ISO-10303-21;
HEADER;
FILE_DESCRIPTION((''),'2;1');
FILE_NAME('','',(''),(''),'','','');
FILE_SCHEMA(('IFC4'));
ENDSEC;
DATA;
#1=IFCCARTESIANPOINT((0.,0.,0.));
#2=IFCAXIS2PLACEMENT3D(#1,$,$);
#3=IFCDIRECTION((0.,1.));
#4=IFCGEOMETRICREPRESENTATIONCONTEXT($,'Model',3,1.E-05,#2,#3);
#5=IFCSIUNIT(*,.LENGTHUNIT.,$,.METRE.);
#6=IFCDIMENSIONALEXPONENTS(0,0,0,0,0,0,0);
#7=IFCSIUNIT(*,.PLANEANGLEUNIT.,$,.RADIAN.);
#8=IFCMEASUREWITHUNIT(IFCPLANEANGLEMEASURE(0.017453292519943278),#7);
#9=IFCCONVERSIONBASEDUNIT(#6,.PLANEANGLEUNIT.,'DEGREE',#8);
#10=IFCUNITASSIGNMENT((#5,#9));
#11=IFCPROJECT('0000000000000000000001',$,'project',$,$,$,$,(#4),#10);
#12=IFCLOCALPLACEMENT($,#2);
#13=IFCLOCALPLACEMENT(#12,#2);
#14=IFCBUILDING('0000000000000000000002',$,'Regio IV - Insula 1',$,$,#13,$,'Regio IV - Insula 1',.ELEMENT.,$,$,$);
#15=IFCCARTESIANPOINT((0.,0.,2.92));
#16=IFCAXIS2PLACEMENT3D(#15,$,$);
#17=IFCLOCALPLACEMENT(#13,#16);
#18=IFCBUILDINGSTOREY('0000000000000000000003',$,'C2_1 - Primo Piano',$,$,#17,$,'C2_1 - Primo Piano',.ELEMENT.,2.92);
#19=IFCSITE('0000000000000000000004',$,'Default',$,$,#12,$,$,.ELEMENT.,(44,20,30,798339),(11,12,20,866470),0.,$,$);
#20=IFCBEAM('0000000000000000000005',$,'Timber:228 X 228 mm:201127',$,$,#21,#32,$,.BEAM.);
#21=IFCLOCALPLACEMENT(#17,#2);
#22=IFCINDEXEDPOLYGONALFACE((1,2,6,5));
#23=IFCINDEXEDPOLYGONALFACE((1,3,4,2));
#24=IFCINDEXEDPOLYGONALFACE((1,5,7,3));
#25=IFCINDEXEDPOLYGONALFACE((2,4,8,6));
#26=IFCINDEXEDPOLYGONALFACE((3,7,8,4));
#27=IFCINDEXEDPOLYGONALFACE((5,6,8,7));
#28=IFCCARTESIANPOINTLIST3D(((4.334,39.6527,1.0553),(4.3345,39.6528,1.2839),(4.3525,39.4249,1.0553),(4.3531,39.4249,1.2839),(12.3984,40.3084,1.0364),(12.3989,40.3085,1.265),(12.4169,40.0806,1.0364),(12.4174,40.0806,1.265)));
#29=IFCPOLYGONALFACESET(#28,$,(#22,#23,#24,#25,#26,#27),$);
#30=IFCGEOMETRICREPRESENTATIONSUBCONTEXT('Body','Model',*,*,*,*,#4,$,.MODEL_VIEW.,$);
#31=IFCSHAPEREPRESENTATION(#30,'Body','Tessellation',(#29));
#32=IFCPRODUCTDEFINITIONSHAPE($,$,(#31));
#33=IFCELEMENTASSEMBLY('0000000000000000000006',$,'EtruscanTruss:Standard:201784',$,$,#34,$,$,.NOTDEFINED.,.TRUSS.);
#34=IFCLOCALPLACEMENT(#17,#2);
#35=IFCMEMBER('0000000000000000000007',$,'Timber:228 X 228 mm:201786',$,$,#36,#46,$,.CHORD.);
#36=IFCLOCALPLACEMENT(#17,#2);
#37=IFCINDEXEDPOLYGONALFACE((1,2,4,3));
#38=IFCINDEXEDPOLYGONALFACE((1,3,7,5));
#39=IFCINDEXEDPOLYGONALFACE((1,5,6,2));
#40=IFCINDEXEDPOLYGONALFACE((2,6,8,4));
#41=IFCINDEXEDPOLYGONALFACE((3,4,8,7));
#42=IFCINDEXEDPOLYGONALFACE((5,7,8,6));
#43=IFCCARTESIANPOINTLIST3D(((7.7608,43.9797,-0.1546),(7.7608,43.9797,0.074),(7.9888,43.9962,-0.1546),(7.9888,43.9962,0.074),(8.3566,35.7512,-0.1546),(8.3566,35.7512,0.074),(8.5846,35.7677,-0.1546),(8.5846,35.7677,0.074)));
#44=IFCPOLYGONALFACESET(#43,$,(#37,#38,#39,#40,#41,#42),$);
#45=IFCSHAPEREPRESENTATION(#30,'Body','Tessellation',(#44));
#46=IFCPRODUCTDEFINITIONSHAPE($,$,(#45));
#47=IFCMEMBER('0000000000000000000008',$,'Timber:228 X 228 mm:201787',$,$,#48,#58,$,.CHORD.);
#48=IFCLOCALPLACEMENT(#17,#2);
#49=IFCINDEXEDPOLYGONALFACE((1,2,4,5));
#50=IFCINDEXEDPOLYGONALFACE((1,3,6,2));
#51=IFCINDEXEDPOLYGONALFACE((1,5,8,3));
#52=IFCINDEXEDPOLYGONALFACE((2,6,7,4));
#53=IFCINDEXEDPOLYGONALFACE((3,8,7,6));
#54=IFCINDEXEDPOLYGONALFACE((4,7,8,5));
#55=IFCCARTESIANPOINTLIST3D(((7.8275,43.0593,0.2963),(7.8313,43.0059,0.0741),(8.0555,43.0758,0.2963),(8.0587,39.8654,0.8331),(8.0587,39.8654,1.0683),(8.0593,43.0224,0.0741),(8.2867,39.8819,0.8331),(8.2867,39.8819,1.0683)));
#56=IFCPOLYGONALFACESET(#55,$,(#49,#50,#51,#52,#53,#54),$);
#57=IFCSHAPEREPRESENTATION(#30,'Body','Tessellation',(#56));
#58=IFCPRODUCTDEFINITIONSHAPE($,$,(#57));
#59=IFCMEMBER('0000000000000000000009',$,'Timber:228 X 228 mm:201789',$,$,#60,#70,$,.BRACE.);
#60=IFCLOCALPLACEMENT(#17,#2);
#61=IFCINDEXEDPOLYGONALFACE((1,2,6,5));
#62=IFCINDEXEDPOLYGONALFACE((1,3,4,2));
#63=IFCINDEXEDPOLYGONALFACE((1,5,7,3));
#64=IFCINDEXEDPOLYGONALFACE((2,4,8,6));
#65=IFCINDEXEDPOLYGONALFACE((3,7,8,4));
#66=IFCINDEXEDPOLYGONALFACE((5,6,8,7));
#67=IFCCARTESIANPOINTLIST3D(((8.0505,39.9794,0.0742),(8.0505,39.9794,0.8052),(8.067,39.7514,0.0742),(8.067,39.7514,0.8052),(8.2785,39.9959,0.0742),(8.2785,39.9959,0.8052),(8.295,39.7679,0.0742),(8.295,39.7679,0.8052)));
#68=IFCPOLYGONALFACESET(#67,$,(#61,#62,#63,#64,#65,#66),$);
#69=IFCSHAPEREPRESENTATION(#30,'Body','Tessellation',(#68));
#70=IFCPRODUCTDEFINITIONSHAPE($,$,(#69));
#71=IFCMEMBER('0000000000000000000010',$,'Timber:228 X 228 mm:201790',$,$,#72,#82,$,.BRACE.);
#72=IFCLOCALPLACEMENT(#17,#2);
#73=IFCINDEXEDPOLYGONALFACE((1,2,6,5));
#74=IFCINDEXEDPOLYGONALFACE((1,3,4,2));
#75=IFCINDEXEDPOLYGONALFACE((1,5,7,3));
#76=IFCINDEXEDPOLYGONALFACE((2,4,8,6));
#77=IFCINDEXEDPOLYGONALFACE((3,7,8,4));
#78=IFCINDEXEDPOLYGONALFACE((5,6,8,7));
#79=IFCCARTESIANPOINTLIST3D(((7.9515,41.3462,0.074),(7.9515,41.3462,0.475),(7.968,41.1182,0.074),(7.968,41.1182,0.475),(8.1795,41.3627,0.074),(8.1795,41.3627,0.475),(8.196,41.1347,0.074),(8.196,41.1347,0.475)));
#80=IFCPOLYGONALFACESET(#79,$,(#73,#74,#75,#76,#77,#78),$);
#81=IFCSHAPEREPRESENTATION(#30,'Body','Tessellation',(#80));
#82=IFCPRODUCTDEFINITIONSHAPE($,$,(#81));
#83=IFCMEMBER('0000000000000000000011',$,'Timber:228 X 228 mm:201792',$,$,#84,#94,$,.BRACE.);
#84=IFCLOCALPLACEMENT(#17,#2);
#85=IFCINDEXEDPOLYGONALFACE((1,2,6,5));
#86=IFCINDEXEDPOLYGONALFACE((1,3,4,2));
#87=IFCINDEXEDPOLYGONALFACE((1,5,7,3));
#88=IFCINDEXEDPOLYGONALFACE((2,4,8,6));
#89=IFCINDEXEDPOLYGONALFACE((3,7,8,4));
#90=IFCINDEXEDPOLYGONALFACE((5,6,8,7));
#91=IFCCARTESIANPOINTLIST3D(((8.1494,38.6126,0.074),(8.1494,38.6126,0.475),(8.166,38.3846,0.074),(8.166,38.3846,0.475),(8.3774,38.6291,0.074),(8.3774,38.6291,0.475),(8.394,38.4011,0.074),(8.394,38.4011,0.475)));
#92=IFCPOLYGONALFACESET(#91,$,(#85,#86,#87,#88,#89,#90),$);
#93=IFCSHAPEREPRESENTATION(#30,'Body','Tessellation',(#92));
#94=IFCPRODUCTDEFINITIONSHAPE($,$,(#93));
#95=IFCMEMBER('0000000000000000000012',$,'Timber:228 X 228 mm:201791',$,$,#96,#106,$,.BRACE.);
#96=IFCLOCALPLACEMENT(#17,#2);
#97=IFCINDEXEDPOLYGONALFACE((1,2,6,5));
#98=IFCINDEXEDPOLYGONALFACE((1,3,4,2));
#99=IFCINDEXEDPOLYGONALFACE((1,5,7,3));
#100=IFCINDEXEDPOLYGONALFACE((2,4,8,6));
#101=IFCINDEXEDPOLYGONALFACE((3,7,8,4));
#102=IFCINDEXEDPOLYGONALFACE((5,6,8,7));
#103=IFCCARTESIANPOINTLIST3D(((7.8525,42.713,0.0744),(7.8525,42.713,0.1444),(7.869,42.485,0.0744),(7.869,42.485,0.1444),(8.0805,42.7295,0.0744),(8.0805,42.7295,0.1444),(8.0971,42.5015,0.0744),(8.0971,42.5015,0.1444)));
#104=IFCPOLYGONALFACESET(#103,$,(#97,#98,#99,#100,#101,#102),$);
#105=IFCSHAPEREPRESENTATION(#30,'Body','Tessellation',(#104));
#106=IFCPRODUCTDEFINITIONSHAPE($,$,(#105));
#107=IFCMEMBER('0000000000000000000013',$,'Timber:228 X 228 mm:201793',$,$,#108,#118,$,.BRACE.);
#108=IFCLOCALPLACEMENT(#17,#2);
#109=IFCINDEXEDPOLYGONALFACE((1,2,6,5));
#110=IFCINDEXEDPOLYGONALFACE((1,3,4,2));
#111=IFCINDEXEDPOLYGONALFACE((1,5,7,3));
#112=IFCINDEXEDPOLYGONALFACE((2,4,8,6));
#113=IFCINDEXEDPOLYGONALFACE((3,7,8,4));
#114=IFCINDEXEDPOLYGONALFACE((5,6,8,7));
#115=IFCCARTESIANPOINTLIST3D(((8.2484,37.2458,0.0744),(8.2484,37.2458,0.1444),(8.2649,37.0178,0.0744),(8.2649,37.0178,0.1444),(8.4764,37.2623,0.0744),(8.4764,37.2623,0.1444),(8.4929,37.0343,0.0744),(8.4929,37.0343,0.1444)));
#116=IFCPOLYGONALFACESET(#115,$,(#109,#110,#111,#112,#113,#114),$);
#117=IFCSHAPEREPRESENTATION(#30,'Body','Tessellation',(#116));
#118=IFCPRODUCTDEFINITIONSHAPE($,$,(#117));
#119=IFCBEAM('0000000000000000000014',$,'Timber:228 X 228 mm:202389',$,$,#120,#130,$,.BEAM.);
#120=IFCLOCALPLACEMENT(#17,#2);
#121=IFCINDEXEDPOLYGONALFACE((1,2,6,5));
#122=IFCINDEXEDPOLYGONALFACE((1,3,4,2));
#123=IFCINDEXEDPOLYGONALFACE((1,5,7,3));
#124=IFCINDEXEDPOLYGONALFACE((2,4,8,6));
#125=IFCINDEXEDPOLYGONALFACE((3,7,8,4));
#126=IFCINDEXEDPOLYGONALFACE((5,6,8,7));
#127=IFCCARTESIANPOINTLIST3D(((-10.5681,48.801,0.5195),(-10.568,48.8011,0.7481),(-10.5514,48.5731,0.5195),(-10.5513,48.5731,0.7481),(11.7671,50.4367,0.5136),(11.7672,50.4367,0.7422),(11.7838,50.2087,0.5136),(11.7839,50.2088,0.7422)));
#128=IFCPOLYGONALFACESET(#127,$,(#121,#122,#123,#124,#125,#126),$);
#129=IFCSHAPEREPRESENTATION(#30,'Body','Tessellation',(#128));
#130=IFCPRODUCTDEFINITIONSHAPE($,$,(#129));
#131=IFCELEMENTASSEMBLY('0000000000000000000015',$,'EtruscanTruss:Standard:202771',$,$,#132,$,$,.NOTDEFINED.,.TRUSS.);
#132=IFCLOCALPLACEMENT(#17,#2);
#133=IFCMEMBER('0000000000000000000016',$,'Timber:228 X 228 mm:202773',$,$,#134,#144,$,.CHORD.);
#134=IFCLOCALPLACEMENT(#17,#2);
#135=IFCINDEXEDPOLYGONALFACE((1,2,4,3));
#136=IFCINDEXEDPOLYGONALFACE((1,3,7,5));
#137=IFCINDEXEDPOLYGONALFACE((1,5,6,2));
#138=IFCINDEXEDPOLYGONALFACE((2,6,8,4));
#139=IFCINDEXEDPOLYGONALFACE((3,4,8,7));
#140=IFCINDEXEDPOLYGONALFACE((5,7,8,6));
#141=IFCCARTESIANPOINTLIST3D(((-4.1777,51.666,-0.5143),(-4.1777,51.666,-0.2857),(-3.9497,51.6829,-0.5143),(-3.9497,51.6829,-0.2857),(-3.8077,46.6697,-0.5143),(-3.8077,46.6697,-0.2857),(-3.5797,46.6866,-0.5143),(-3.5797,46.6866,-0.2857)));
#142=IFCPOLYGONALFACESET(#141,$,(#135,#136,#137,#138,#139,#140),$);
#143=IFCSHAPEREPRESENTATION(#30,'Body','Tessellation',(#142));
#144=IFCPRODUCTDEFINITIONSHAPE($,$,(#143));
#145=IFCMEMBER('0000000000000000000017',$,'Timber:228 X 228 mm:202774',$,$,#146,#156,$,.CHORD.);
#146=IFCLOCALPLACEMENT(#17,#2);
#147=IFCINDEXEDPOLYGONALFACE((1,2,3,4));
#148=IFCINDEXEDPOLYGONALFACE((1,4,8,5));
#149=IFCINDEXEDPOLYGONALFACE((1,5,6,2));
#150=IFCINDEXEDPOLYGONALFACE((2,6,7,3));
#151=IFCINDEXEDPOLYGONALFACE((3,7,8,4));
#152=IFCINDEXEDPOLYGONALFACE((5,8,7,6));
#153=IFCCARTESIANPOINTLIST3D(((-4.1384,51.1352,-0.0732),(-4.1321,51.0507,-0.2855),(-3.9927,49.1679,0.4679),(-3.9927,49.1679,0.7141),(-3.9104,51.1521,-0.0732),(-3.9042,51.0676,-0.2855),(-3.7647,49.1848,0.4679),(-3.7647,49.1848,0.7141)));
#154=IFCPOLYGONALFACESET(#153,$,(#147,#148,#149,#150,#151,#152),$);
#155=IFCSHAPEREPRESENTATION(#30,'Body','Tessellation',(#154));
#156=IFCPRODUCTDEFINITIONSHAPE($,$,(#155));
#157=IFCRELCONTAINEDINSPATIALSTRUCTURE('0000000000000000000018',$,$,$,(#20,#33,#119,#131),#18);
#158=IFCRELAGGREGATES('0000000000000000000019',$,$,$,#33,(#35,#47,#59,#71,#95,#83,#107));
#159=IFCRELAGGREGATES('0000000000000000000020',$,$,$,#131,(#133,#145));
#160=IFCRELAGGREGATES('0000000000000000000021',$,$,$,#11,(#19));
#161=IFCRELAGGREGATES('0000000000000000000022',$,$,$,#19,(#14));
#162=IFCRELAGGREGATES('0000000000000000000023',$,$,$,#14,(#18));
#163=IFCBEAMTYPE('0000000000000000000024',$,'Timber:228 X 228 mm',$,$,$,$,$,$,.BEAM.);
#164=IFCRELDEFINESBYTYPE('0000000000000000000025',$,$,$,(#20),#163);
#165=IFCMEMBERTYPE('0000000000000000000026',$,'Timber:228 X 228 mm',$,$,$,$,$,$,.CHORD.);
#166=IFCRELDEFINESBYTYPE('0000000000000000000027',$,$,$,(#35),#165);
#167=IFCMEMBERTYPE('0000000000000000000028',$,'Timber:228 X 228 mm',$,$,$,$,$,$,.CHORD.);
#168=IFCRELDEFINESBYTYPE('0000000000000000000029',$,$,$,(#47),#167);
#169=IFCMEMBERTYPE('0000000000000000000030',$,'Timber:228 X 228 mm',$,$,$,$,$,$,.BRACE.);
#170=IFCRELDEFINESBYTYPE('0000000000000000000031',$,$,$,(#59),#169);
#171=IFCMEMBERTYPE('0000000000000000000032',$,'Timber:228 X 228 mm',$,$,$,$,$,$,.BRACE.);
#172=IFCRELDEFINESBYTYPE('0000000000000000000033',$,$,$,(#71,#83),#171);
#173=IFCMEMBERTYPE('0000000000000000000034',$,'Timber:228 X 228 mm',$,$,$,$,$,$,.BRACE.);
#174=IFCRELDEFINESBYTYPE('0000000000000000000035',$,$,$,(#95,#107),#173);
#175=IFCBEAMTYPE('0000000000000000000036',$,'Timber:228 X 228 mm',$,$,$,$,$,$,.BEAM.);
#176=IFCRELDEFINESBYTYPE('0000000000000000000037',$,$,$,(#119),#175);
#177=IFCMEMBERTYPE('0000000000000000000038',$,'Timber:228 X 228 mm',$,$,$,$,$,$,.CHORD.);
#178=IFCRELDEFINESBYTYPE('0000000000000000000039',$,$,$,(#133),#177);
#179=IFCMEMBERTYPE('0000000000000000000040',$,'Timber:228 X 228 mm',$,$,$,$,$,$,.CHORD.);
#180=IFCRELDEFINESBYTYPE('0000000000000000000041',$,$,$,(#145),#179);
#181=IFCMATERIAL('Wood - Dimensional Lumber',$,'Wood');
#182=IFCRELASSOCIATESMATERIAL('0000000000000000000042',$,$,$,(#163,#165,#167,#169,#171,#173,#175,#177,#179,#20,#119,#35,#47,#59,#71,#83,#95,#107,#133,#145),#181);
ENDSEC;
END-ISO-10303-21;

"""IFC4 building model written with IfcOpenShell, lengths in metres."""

from ifc_helpers import new_model, entity, si_unit, converted_unit, direction, frame, frame_2d, origin, origin_2d_with_axis, place, context, subcontext, project, spatial, rectangle, extrude, clip, halfspace, source, transform, mapped, material, material_profile, profile_set, profile_usage, type_object, type_shapes, element, aggregate, save


model = new_model("IFC4")

# Units and contexts
model_context = context("Model", 3, precision=1e-05, world=origin(), true_north=direction((0.0, 1.0)))
body_context = subcontext(model_context, "Body", "Model", "MODEL_VIEW")
ifc_project = project(units=[si_unit("LENGTHUNIT", "METRE"), converted_unit("PLANEANGLEUNIT", "DEGREE", entity("IfcPlaneAngleMeasure", 0.017453292519943278), si_unit("PLANEANGLEUNIT", "RADIAN"), dimensions=[0, 0, 0, 0, 0, 0, 0])], contexts=[model_context])

# Site, building, storey
site_placement = place(None, origin())
site = spatial("IfcSite", under=ifc_project, at=site_placement, Name="Default", CompositionType="ELEMENT", RefLatitude=(44, 20, 30, 798339), RefLongitude=(11, 12, 20, 866470), RefElevation=0.0)
building_placement = place(site_placement, origin())
building = spatial("IfcBuilding", under=site, at=building_placement, Name="Regio IV - Insula 1", LongName="Regio IV - Insula 1", CompositionType="ELEMENT")
storey_placement = place(building_placement, frame((0.0, 0.0, 2.92)))
storey = spatial("IfcBuildingStorey", under=building, at=storey_placement, Name="C2_1 - Primo Piano", LongName="C2_1 - Primo Piano", CompositionType="ELEMENT", Elevation=2.92)

# Beam
ifc_material_1 = material(Name="Wood - Dimensional Lumber", Category="Wood")
ifc_material_profile = material_profile(ifc_material_1, rectangle(XDim=8.091, YDim=0.2286, at=frame_2d((0.0, 0.0), x_axis=(1.0, 0.0))), Name="228 X 228 mm")
ifc_profile_set = profile_set([ifc_material_profile], Name="228 X 228 mm")
ifc_profile_usage_1 = profile_usage(ifc_profile_set, cardinal=1)
beam_type_1 = type_object("IfcBeamType", Name="Timber:228 X 228 mm", PredefinedType="BEAM", material=ifc_profile_set)
shared_shape_1 = source(origin(), body_context, "Body", "SweptSolid", [
    extrude(rectangle(XDim=8.091, YDim=0.2286, at=frame_2d((0.0, 0.0), x_axis=(1.0, 0.0))), frame((0.0, 0.0, -0.1143), z_axis=(0.0, 0.0, 1.0), x_axis=(-1.0, 0.0, 0.0)), (0.0, 0.0, 1.0), 0.2286),
])
type_shapes(beam_type_1, [shared_shape_1])
beam_1_placement = place(storey_placement, frame((8.3757, 39.8667, 1.1602), z_axis=(0.002334, 0.00019, 0.999997), x_axis=(-0.996708, -0.081042, 0.002342)))
element("IfcBeam", 1, at=beam_1_placement, inside=storey, type_object=beam_type_1, material=ifc_profile_usage_1, Name="Timber:228 X 228 mm:201127", PredefinedType="BEAM", context=body_context, shape_type="MappedRepresentation", body=[
    mapped(shared_shape_1, transform((0.0, 0.0, 0.0), scale=1.0)),
])

# Element assembly, members
assembly_1_placement = place(storey_placement, origin())
assembly_1 = element("IfcElementAssembly", 2, at=assembly_1_placement, inside=storey, Name="EtruscanTruss:Standard:201784", AssemblyPlace="NOTDEFINED", PredefinedType="TRUSS")
ifc_profile_usage_2 = profile_usage(ifc_profile_set)
member_type_1 = type_object("IfcMemberType", Name="Timber:228 X 228 mm", PredefinedType="CHORD", material=ifc_profile_set)
shared_shape_2 = source(origin(), body_context, "Body", "SweptSolid", [
    extrude(rectangle(XDim=8.25, YDim=0.2286, at=origin_2d_with_axis()), frame((0.0, 0.0, -0.1143), z_axis=(0.0, 0.0, 1.0), x_axis=(-1.0, 0.0, 0.0)), (0.0, 0.0, 1.0), 0.2286),
])
type_shapes(member_type_1, [shared_shape_2])
member_1_placement = place(assembly_1_placement, frame((8.1727, 39.8737, -0.0403), z_axis=(0.0, 0.0, 1.0), x_axis=(0.07222, -0.997389, 0.0)))
member_1 = element("IfcMember", 3, at=member_1_placement, type_object=member_type_1, material=ifc_profile_usage_2, Name="Timber:228 X 228 mm:201786", PredefinedType="CHORD", context=body_context, shape_type="MappedRepresentation", body=[
    mapped(shared_shape_2, transform((0.0, 0.0, 0.0), scale=1.0)),
])
member_type_2 = type_object("IfcMemberType", Name="Timber:228 X 228 mm", PredefinedType="CHORD", material=ifc_profile_set)
shared_shape_3 = source(origin(), body_context, "Body", "Clipping", [
    clip(extrude(rectangle(XDim=0.2286, YDim=0.2286, at=frame_2d((0.0, 0.0), x_axis=(0.0, 1.0))), frame((7.9434, 43.0409, 3.1052), z_axis=(0.070209, -0.969616, 0.234342), x_axis=(-0.997389, -0.07222, 0.0)), (0.0, 0.0, 1.0), 3.294), halfspace(frame((8.1727, 39.8737, 3.9883), z_axis=(0.07222, -0.997389, 0.0), x_axis=(0.997389, 0.07222, 0.0)), False)),
])
type_shapes(member_type_2, [shared_shape_3])
member_2_placement = place(assembly_1_placement, frame((0.0, 0.0, -2.92)))
member_2 = element("IfcMember", 4, at=member_2_placement, type_object=member_type_2, material=ifc_profile_usage_2, Name="Timber:228 X 228 mm:201787", PredefinedType="CHORD", context=body_context, shape_type="MappedRepresentation", body=[
    mapped(shared_shape_3, transform((0.0, 0.0, 0.0), scale=1.0)),
])
member_type_3 = type_object("IfcMemberType", Name="Timber:228 X 228 mm", PredefinedType="BRACE", material=ifc_profile_set)
shared_shape_4 = source(origin(), body_context, "Body", "SweptSolid", [
    extrude(rectangle(XDim=0.731, YDim=0.2286, at=origin_2d_with_axis()), frame((-0.0155, 0.0, -0.1143), z_axis=(0.0, 0.0, 1.0), x_axis=(-1.0, 0.0, 0.0)), (0.0, 0.0, 1.0), 0.2286),
])
type_shapes(member_type_3, [shared_shape_4])
member_3_placement = place(assembly_1_placement, frame((8.1727, 39.8737, 0.4552), z_axis=(0.07222, -0.997389, 0.0), x_axis=(0.0, 0.0, 1.0)))
member_3 = element("IfcMember", 5, at=member_3_placement, type_object=member_type_3, material=ifc_profile_usage_2, Name="Timber:228 X 228 mm:201789", PredefinedType="BRACE", context=body_context, shape_type="MappedRepresentation", body=[
    mapped(shared_shape_4, transform((0.0, 0.0, 0.0), scale=1.0)),
])
member_type_4 = type_object("IfcMemberType", Name="Timber:228 X 228 mm", PredefinedType="BRACE", material=ifc_profile_set)
shared_shape_5 = source(origin(), body_context, "Body", "SweptSolid", [
    extrude(rectangle(XDim=0.401, YDim=0.2286, at=origin_2d_with_axis()), frame((-0.0155, 0.0, -0.1143), z_axis=(0.0, 0.0, 1.0), x_axis=(-1.0, 0.0, 0.0)), (0.0, 0.0, 1.0), 0.2286),
])
type_shapes(member_type_4, [shared_shape_5])
member_4_placement = place(assembly_1_placement, frame((8.0738, 41.2405, 0.29), z_axis=(0.07222, -0.997389, 0.0), x_axis=(0.0, 0.0, 1.0)))
member_4 = element("IfcMember", 6, at=member_4_placement, type_object=member_type_4, material=ifc_profile_usage_2, Name="Timber:228 X 228 mm:201790", PredefinedType="BRACE", context=body_context, shape_type="MappedRepresentation", body=[
    mapped(shared_shape_5, transform((0.0, 0.0, 0.0), scale=1.0)),
])
member_5_placement = place(assembly_1_placement, frame((8.2717, 38.5069, 0.29), z_axis=(0.07222, -0.997389, 0.0), x_axis=(0.0, 0.0, 1.0)))
member_5 = element("IfcMember", 7, at=member_5_placement, type_object=member_type_4, material=ifc_profile_usage_2, Name="Timber:228 X 228 mm:201792", PredefinedType="BRACE", context=body_context, shape_type="MappedRepresentation", body=[
    mapped(shared_shape_5, transform((0.0, 0.0, 0.0), scale=1.0)),
])
member_type_5 = type_object("IfcMemberType", Name="Timber:228 X 228 mm", PredefinedType="BRACE", material=ifc_profile_set)
shared_shape_6 = source(origin(), body_context, "Body", "SweptSolid", [
    extrude(rectangle(XDim=0.07, YDim=0.2286, at=origin_2d_with_axis()), frame((-0.0155, 0.0, -0.1143), z_axis=(0.0, 0.0, 1.0), x_axis=(-1.0, 0.0, 0.0)), (0.0, 0.0, 1.0), 0.2286),
])
type_shapes(member_type_5, [shared_shape_6])
member_6_placement = place(assembly_1_placement, frame((7.9748, 42.6073, 0.1249), z_axis=(0.07222, -0.997389, 0.0), x_axis=(0.0, 0.0, 1.0)))
member_6 = element("IfcMember", 8, at=member_6_placement, type_object=member_type_5, material=ifc_profile_usage_2, Name="Timber:228 X 228 mm:201791", PredefinedType="BRACE", context=body_context, shape_type="MappedRepresentation", body=[
    mapped(shared_shape_6, transform((0.0, 0.0, 0.0), scale=1.0)),
])
member_7_placement = place(assembly_1_placement, frame((8.3707, 37.1401, 0.1249), z_axis=(0.07222, -0.997389, 0.0), x_axis=(0.0, 0.0, 1.0)))
member_7 = element("IfcMember", 9, at=member_7_placement, type_object=member_type_5, material=ifc_profile_usage_2, Name="Timber:228 X 228 mm:201793", PredefinedType="BRACE", context=body_context, shape_type="MappedRepresentation", body=[
    mapped(shared_shape_6, transform((0.0, 0.0, 0.0), scale=1.0)),
])
aggregate(assembly_1, [member_1, member_2, member_3, member_4, member_6, member_5, member_7])

# Beam
beam_type_2 = type_object("IfcBeamType", Name="Timber:228 X 228 mm", PredefinedType="BEAM", material=ifc_profile_set)
shared_shape_7 = source(origin(), body_context, "Body", "SweptSolid", [
    extrude(rectangle(XDim=22.395, YDim=0.2286, at=origin_2d_with_axis()), frame((0.0, 0.0, -0.1143), z_axis=(0.0, 0.0, 1.0), x_axis=(-1.0, 0.0, 0.0)), (0.0, 0.0, 1.0), 0.2286),
])
type_shapes(beam_type_2, [shared_shape_7])
beam_2_placement = place(storey_placement, frame((0.6079, 49.5049, 0.6309), z_axis=(0.000266, 0.000019, 1.0), x_axis=(-0.997329, -0.073038, 0.000267)))
element("IfcBeam", 10, at=beam_2_placement, inside=storey, type_object=beam_type_2, material=ifc_profile_usage_1, Name="Timber:228 X 228 mm:202389", PredefinedType="BEAM", context=body_context, shape_type="MappedRepresentation", body=[
    mapped(shared_shape_7, transform((0.0, 0.0, 0.0), scale=1.0)),
])

# Element assembly, members
assembly_2_placement = place(storey_placement, origin())
assembly_2 = element("IfcElementAssembly", 11, at=assembly_2_placement, inside=storey, Name="EtruscanTruss:Standard:202771", AssemblyPlace="NOTDEFINED", PredefinedType="TRUSS")
member_type_6 = type_object("IfcMemberType", Name="Timber:228 X 228 mm", PredefinedType="CHORD", material=ifc_profile_set)
shared_shape_8 = source(origin(), body_context, "Body", "SweptSolid", [
    extrude(rectangle(XDim=5.01, YDim=0.2286, at=origin_2d_with_axis()), frame((0.0, 0.0, -0.1143), z_axis=(0.0, 0.0, 1.0), x_axis=(-1.0, 0.0, 0.0)), (0.0, 0.0, 1.0), 0.2286),
])
type_shapes(member_type_6, [shared_shape_8])
member_8_placement = place(assembly_2_placement, frame((-3.8787, 49.1763, -0.4), z_axis=(0.0, 0.0, 1.0), x_axis=(0.073857, -0.997269, 0.0)))
member_8 = element("IfcMember", 12, at=member_8_placement, type_object=member_type_6, material=ifc_profile_usage_2, Name="Timber:228 X 228 mm:202773", PredefinedType="CHORD", context=body_context, shape_type="MappedRepresentation", body=[
    mapped(shared_shape_8, transform((0.0, 0.0, 0.0), scale=1.0)),
])
member_type_7 = type_object("IfcMemberType", Name="Timber:228 X 228 mm", PredefinedType="CHORD", material=ifc_profile_set)
shared_shape_9 = source(origin(), body_context, "Body", "Clipping", [
    clip(extrude(rectangle(XDim=0.2286, YDim=0.2286, at=frame_2d((0.0, 0.0), x_axis=(0.0, 1.0))), frame((-4.0213, 51.1014, 2.7407), z_axis=(0.068596, -0.92624, 0.370641), x_axis=(-0.997269, -0.073857, 0.0)), (0.0, 0.0, 1.0), 2.124), halfspace(frame((-3.8787, 49.1763, 3.6341), z_axis=(0.073857, -0.997269, 0.0), x_axis=(0.997269, 0.073857, 0.0)), False)),
])
type_shapes(member_type_7, [shared_shape_9])
member_9_placement = place(assembly_2_placement, frame((0.0, 0.0, -2.92)))
member_9 = element("IfcMember", 13, at=member_9_placement, type_object=member_type_7, material=ifc_profile_usage_2, Name="Timber:228 X 228 mm:202774", PredefinedType="CHORD", context=body_context, shape_type="MappedRepresentation", body=[
    mapped(shared_shape_9, transform((0.0, 0.0, 0.0), scale=1.0)),
])
aggregate(assembly_2, [member_8, member_9])

save(model, "model.ifc")
